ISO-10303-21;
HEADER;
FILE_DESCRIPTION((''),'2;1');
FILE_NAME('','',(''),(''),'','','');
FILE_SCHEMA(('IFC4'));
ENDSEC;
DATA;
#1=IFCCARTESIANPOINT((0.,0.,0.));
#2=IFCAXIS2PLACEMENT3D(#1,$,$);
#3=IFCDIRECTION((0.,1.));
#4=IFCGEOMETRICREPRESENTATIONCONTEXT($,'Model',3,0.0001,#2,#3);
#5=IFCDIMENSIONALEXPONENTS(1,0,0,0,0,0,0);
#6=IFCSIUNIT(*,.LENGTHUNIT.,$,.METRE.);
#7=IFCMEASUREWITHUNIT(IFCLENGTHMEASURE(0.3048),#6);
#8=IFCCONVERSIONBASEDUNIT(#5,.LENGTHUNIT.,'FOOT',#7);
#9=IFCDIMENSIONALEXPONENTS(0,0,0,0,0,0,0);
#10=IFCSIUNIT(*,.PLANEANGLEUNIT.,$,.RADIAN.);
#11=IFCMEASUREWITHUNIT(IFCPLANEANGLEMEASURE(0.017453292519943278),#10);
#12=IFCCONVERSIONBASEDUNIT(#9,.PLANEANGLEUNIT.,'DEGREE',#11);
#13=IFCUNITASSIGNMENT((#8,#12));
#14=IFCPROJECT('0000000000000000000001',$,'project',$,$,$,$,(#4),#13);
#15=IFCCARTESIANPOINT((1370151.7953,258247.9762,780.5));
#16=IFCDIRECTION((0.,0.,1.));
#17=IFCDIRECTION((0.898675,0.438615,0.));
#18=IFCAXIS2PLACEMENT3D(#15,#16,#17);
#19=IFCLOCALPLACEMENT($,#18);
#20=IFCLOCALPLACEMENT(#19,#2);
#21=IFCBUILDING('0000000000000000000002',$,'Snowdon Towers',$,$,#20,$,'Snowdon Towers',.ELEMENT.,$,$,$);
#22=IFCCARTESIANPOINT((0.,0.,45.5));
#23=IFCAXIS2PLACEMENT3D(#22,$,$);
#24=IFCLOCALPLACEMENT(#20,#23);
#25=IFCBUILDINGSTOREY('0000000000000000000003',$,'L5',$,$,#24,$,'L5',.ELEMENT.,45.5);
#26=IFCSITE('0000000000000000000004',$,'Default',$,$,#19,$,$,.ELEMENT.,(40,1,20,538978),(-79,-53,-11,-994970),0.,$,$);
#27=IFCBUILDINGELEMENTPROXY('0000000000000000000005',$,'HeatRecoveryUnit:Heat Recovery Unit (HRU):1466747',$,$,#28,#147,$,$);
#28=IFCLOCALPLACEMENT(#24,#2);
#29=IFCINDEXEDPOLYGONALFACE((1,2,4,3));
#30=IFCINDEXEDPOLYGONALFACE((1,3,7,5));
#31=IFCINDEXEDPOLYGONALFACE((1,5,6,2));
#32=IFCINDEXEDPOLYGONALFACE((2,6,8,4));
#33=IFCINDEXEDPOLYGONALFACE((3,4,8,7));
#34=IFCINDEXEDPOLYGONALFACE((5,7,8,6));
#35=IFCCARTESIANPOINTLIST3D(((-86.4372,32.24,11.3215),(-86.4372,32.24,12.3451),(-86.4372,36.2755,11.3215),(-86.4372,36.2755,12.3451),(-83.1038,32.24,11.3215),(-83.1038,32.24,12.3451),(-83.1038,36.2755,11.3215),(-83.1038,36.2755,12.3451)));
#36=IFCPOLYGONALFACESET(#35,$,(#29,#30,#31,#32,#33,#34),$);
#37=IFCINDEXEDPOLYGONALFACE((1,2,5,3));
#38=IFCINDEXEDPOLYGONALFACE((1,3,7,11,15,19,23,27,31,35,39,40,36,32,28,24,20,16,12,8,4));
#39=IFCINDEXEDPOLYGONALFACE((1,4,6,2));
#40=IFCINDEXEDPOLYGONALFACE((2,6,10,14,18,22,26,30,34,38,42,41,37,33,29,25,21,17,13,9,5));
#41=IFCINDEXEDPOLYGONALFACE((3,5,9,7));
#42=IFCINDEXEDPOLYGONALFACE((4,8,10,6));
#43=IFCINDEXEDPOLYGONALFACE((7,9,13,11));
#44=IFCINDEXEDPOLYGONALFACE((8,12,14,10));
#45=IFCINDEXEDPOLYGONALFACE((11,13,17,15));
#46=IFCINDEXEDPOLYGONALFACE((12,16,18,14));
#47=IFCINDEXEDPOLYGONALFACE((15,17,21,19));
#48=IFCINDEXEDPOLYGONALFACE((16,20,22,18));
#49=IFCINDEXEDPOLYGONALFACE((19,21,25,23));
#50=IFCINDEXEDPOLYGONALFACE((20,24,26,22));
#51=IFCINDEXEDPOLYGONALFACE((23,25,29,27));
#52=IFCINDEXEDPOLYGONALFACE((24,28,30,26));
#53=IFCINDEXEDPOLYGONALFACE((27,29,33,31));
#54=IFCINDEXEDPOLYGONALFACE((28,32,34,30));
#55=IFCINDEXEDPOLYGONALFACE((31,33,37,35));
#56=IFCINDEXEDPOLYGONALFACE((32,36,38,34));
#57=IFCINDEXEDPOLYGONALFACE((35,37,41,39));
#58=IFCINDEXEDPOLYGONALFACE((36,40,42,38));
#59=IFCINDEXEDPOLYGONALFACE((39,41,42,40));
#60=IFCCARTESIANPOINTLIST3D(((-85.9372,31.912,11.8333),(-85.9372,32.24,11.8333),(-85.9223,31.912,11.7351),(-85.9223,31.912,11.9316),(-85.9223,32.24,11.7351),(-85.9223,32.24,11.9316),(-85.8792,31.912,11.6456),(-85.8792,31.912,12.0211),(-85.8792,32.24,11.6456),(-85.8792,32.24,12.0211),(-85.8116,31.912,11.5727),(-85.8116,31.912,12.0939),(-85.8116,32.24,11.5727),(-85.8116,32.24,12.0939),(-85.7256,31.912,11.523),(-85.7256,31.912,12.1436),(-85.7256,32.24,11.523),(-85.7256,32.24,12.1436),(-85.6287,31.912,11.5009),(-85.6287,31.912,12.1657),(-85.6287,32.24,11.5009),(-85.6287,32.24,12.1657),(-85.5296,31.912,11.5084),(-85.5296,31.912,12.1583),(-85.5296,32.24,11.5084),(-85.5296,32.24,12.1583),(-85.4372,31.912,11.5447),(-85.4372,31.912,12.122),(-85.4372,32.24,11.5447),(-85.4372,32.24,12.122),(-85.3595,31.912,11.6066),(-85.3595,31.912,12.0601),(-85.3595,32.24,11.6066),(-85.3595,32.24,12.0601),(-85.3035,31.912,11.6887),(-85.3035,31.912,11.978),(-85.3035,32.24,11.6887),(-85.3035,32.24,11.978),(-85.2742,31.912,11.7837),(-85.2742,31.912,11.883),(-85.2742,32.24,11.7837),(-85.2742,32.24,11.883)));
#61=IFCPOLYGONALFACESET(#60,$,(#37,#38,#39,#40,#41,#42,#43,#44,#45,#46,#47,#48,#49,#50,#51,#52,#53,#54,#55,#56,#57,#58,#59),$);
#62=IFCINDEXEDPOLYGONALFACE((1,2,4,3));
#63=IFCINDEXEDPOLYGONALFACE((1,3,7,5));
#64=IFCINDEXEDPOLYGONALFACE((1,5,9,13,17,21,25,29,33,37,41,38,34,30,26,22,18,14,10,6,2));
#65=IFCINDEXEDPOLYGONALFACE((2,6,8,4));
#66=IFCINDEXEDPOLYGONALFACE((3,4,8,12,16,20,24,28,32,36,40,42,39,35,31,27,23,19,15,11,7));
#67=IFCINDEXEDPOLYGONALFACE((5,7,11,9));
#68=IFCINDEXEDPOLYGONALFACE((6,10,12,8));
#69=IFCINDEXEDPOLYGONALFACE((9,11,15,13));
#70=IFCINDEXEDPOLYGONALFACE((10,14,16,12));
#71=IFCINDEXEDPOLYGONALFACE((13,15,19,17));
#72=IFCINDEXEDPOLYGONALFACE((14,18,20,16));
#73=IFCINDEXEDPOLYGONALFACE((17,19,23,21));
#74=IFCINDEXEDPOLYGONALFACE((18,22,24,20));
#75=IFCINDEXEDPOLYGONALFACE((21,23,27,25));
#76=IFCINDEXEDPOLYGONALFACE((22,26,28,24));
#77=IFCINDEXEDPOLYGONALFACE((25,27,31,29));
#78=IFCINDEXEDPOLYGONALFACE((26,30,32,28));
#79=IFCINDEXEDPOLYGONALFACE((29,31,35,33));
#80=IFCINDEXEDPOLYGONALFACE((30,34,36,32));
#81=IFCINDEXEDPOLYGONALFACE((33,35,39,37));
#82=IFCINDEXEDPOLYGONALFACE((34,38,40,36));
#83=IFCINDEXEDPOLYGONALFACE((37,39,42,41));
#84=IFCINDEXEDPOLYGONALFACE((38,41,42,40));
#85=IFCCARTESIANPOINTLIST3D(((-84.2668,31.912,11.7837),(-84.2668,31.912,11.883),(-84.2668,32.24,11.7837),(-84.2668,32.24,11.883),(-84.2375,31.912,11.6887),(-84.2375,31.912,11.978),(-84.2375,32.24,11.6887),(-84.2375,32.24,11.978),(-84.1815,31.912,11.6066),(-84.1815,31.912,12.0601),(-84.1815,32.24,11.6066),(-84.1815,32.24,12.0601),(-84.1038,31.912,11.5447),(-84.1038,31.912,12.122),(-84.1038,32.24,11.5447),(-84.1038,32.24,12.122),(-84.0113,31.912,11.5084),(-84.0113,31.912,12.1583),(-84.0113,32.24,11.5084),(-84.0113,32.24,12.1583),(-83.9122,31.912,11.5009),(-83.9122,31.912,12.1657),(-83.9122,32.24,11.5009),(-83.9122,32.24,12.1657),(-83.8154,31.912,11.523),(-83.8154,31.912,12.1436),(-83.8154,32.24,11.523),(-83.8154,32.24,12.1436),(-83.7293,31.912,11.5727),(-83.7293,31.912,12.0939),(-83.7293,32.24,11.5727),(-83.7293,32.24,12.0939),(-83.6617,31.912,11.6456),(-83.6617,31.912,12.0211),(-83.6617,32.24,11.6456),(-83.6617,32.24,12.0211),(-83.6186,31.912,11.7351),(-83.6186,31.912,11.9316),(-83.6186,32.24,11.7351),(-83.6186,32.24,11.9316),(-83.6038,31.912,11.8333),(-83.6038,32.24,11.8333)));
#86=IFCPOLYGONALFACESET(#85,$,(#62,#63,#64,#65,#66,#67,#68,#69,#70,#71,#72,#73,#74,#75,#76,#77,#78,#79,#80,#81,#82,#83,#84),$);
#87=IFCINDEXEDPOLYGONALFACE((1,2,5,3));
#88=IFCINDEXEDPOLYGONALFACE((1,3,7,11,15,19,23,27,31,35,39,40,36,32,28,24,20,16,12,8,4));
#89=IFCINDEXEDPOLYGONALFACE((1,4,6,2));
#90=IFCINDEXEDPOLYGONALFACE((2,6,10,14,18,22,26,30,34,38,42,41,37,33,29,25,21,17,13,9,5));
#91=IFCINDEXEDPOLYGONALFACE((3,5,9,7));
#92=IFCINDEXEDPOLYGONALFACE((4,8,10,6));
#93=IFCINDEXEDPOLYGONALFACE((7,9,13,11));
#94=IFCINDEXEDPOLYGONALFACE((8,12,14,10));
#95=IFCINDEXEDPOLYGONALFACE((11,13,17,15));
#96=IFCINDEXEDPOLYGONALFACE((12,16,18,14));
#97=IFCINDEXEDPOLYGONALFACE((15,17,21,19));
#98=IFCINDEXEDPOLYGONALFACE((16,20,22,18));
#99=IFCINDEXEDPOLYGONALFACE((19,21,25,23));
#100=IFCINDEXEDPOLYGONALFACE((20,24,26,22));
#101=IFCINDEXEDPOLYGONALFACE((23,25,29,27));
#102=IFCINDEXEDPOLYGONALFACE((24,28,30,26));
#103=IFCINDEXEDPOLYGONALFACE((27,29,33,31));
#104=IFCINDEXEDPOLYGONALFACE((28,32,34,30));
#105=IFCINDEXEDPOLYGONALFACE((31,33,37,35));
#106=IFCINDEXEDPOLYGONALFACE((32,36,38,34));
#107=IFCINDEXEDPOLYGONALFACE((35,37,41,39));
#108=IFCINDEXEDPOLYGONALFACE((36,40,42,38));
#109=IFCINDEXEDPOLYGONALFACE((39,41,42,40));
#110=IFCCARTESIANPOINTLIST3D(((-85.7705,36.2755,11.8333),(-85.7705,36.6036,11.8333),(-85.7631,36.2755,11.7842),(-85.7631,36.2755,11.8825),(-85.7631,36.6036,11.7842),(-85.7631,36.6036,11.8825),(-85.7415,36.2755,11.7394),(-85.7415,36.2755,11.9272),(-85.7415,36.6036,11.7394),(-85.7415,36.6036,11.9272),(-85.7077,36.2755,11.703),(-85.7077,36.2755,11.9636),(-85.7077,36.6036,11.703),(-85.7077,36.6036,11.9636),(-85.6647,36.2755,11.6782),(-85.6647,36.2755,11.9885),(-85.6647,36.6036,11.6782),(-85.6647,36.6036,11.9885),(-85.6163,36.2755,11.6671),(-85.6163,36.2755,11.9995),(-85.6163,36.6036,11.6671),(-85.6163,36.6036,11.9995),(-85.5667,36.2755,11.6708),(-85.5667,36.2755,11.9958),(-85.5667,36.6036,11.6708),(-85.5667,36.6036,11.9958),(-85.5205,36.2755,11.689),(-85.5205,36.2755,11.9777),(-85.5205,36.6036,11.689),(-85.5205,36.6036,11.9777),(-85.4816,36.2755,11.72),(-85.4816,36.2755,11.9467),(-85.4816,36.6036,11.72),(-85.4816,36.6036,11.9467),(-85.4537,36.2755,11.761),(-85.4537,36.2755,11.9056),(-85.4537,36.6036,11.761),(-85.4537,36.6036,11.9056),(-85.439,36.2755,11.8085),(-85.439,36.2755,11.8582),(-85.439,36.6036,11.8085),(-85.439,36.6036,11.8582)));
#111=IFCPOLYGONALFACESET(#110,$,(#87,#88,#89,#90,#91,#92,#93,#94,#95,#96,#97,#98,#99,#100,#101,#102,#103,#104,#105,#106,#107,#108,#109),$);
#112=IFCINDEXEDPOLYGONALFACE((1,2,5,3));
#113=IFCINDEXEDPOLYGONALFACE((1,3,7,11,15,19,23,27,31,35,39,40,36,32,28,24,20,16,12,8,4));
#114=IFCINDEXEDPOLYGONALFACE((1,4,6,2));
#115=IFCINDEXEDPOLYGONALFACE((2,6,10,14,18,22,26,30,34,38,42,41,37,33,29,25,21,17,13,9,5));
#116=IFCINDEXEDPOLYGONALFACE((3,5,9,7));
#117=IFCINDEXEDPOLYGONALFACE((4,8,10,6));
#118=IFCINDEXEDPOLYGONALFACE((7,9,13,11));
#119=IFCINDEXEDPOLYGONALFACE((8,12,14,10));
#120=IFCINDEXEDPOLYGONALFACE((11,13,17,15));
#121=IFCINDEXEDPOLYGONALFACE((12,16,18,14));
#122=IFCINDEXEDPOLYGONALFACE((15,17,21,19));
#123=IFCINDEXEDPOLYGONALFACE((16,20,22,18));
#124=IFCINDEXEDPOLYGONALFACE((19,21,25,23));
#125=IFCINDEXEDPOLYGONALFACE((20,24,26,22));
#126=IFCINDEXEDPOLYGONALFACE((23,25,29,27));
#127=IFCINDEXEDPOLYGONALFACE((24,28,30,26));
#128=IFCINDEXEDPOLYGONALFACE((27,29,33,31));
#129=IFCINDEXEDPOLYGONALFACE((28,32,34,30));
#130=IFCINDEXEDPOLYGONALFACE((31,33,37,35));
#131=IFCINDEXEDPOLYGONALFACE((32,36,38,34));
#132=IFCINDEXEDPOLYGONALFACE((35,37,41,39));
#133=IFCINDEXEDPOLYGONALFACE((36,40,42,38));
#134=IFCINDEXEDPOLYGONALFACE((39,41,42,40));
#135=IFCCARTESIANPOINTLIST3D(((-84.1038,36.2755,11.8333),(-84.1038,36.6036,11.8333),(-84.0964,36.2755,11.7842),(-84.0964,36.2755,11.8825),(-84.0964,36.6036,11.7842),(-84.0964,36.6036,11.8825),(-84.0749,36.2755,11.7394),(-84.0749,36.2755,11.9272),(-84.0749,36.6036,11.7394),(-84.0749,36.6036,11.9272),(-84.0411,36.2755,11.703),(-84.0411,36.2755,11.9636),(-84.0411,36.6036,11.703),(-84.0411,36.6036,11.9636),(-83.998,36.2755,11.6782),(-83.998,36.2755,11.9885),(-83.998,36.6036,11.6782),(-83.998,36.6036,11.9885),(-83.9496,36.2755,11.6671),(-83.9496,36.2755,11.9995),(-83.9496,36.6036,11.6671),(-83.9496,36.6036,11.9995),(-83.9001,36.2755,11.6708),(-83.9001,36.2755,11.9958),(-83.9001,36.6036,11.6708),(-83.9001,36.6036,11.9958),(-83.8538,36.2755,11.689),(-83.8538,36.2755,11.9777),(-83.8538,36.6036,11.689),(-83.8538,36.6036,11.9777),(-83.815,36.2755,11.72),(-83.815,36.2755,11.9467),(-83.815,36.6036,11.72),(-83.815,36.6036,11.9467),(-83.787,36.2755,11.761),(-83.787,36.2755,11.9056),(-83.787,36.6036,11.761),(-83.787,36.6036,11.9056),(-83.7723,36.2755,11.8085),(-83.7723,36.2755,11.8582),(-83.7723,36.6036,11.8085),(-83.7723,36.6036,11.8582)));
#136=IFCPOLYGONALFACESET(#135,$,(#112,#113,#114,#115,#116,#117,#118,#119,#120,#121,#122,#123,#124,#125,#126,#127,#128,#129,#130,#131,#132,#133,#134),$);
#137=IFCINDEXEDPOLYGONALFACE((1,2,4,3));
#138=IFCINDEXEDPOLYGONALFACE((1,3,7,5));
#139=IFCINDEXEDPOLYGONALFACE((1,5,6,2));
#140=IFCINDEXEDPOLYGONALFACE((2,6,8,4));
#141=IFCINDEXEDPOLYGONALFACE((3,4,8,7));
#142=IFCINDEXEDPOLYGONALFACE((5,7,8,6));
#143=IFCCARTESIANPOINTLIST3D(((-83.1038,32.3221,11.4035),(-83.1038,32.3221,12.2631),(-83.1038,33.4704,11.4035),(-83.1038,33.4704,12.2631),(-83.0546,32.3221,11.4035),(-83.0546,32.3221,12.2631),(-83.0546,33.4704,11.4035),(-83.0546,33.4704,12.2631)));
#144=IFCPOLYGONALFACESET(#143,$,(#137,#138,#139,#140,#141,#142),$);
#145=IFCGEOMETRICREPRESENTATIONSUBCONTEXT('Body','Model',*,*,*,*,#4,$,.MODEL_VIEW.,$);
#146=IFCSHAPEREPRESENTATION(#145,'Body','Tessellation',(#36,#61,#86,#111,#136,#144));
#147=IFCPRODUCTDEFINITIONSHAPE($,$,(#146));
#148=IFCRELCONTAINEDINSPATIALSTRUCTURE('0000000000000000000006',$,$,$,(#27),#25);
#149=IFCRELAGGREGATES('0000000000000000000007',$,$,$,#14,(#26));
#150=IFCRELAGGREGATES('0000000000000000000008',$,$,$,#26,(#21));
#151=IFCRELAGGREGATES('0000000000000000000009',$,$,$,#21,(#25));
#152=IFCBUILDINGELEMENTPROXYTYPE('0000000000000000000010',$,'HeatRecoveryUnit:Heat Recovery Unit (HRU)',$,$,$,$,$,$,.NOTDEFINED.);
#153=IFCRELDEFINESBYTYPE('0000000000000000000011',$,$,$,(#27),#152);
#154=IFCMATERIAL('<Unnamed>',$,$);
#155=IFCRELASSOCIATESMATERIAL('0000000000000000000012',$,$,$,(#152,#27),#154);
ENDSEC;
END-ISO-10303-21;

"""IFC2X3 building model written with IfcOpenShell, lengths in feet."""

from ifc_helpers import new_model, entity, si_unit, converted_unit, direction, frame, frame_2d, origin, origin_2d_with_axis, place, context, subcontext, project, spatial, rectangle, circle, extrude, source, transform, mapped, material, type_object, type_shapes, element, save


model = new_model("IFC2X3")

# Units and contexts
model_context = context("Model", 3, precision=0.0001, world=origin(), true_north=direction((0.0, 1.0)))
body_context = subcontext(model_context, "Body", "Model", "MODEL_VIEW")
ifc_project = project(units=[converted_unit("LENGTHUNIT", "FOOT", entity("IfcLengthMeasure", 0.3048), si_unit("LENGTHUNIT", "METRE"), dimensions=[1, 0, 0, 0, 0, 0, 0]), converted_unit("PLANEANGLEUNIT", "DEGREE", entity("IfcPlaneAngleMeasure", 0.017453292519943278), si_unit("PLANEANGLEUNIT", "RADIAN"), dimensions=[0, 0, 0, 0, 0, 0, 0])], contexts=[model_context])

# Site, building, storey
site_placement = place(None, frame((1370151.7953, 258247.9762, 780.5), z_axis=(0.0, 0.0, 1.0), x_axis=(0.898675, 0.438615, 0.0)))
site = spatial("IfcSite", under=ifc_project, at=site_placement, Name="Default", CompositionType="ELEMENT", RefLatitude=(40, 1, 20, 538978), RefLongitude=(-79, -53, -11, -994970), RefElevation=0.0)
building_placement = place(site_placement, origin())
building = spatial("IfcBuilding", under=site, at=building_placement, Name="Snowdon Towers", LongName="Snowdon Towers", CompositionType="ELEMENT")
storey_placement = place(building_placement, frame((0.0, 0.0, 45.5)))
storey = spatial("IfcBuildingStorey", under=building, at=storey_placement, Name="L5", LongName="L5", CompositionType="ELEMENT", Elevation=45.5)

# Shared definitions
ifc_material = material(Name="<Unnamed>")

# Building element proxy
building_element_proxy_type = type_object("IfcBuildingElementProxyType", Name="HeatRecoveryUnit:Heat Recovery Unit (HRU)", PredefinedType="NOTDEFINED", material=ifc_material)
shared_shape_1 = source(origin(), body_context, "Body", "SweptSolid", [
    extrude(rectangle(XDim=3.3333, YDim=4.0354, at=origin_2d_with_axis()), frame((0.0, 0.0, 0.0), z_axis=(0.0, 0.0, 1.0), x_axis=(-1.0, 0.0, 0.0)), (0.0, 0.0, 1.0), 1.0236),
    extrude(circle(Radius=0.3333, at=frame_2d((0.0, 0.0), x_axis=(1.0, 0.0))), frame((-0.8333, -2.3458, 0.5118), z_axis=(0.0, 1.0, 0.0), x_axis=(-1.0, 0.0, 0.0)), (0.0, 0.0, 1.0), 0.3281),
    extrude(circle(Radius=0.3333, at=frame_2d((0.0, 0.0), x_axis=(1.0, 0.0))), frame((0.8333, -2.3458, 0.5118), z_axis=(0.0, 1.0, 0.0), x_axis=(1.0, 0.0, 0.0)), (0.0, 0.0, 1.0), 0.3281),
    extrude(circle(Radius=0.1667, at=frame_2d((0.0, 0.0), x_axis=(1.0, 0.0))), frame((-0.8333, 2.0177, 0.5118), z_axis=(0.0, 1.0, 0.0), x_axis=(-1.0, 0.0, 0.0)), (0.0, 0.0, 1.0), 0.3281),
    extrude(circle(Radius=0.1667, at=frame_2d((0.0, 0.0), x_axis=(1.0, 0.0))), frame((0.8333, 2.0177, 0.5118), z_axis=(0.0, 1.0, 0.0), x_axis=(-1.0, 0.0, 0.0)), (0.0, 0.0, 1.0), 0.3281),
    extrude(rectangle(XDim=0.0492, YDim=1.1483, at=origin_2d_with_axis()), frame((1.6913, -1.3615, 0.082), z_axis=(0.0, 0.0, 1.0), x_axis=(-1.0, 0.0, 0.0)), (0.0, 0.0, 1.0), 0.8596),
])
type_shapes(building_element_proxy_type, [shared_shape_1])
for number, where, name in (
    (1, (-84.7705, 34.2578, 11.3215), "HeatRecoveryUnit:Heat Recovery Unit (HRU):1466747"),
):
    element("IfcBuildingElementProxy", number, at=place(storey_placement, frame(where)), inside=storey, type_object=building_element_proxy_type, material=ifc_material, Name=name, context=body_context, shape_type="MappedRepresentation", body=[
        mapped(shared_shape_1, transform((0.0, 0.0, 0.0), scale=1.0)),
    ])

save(model, "model.ifc")
